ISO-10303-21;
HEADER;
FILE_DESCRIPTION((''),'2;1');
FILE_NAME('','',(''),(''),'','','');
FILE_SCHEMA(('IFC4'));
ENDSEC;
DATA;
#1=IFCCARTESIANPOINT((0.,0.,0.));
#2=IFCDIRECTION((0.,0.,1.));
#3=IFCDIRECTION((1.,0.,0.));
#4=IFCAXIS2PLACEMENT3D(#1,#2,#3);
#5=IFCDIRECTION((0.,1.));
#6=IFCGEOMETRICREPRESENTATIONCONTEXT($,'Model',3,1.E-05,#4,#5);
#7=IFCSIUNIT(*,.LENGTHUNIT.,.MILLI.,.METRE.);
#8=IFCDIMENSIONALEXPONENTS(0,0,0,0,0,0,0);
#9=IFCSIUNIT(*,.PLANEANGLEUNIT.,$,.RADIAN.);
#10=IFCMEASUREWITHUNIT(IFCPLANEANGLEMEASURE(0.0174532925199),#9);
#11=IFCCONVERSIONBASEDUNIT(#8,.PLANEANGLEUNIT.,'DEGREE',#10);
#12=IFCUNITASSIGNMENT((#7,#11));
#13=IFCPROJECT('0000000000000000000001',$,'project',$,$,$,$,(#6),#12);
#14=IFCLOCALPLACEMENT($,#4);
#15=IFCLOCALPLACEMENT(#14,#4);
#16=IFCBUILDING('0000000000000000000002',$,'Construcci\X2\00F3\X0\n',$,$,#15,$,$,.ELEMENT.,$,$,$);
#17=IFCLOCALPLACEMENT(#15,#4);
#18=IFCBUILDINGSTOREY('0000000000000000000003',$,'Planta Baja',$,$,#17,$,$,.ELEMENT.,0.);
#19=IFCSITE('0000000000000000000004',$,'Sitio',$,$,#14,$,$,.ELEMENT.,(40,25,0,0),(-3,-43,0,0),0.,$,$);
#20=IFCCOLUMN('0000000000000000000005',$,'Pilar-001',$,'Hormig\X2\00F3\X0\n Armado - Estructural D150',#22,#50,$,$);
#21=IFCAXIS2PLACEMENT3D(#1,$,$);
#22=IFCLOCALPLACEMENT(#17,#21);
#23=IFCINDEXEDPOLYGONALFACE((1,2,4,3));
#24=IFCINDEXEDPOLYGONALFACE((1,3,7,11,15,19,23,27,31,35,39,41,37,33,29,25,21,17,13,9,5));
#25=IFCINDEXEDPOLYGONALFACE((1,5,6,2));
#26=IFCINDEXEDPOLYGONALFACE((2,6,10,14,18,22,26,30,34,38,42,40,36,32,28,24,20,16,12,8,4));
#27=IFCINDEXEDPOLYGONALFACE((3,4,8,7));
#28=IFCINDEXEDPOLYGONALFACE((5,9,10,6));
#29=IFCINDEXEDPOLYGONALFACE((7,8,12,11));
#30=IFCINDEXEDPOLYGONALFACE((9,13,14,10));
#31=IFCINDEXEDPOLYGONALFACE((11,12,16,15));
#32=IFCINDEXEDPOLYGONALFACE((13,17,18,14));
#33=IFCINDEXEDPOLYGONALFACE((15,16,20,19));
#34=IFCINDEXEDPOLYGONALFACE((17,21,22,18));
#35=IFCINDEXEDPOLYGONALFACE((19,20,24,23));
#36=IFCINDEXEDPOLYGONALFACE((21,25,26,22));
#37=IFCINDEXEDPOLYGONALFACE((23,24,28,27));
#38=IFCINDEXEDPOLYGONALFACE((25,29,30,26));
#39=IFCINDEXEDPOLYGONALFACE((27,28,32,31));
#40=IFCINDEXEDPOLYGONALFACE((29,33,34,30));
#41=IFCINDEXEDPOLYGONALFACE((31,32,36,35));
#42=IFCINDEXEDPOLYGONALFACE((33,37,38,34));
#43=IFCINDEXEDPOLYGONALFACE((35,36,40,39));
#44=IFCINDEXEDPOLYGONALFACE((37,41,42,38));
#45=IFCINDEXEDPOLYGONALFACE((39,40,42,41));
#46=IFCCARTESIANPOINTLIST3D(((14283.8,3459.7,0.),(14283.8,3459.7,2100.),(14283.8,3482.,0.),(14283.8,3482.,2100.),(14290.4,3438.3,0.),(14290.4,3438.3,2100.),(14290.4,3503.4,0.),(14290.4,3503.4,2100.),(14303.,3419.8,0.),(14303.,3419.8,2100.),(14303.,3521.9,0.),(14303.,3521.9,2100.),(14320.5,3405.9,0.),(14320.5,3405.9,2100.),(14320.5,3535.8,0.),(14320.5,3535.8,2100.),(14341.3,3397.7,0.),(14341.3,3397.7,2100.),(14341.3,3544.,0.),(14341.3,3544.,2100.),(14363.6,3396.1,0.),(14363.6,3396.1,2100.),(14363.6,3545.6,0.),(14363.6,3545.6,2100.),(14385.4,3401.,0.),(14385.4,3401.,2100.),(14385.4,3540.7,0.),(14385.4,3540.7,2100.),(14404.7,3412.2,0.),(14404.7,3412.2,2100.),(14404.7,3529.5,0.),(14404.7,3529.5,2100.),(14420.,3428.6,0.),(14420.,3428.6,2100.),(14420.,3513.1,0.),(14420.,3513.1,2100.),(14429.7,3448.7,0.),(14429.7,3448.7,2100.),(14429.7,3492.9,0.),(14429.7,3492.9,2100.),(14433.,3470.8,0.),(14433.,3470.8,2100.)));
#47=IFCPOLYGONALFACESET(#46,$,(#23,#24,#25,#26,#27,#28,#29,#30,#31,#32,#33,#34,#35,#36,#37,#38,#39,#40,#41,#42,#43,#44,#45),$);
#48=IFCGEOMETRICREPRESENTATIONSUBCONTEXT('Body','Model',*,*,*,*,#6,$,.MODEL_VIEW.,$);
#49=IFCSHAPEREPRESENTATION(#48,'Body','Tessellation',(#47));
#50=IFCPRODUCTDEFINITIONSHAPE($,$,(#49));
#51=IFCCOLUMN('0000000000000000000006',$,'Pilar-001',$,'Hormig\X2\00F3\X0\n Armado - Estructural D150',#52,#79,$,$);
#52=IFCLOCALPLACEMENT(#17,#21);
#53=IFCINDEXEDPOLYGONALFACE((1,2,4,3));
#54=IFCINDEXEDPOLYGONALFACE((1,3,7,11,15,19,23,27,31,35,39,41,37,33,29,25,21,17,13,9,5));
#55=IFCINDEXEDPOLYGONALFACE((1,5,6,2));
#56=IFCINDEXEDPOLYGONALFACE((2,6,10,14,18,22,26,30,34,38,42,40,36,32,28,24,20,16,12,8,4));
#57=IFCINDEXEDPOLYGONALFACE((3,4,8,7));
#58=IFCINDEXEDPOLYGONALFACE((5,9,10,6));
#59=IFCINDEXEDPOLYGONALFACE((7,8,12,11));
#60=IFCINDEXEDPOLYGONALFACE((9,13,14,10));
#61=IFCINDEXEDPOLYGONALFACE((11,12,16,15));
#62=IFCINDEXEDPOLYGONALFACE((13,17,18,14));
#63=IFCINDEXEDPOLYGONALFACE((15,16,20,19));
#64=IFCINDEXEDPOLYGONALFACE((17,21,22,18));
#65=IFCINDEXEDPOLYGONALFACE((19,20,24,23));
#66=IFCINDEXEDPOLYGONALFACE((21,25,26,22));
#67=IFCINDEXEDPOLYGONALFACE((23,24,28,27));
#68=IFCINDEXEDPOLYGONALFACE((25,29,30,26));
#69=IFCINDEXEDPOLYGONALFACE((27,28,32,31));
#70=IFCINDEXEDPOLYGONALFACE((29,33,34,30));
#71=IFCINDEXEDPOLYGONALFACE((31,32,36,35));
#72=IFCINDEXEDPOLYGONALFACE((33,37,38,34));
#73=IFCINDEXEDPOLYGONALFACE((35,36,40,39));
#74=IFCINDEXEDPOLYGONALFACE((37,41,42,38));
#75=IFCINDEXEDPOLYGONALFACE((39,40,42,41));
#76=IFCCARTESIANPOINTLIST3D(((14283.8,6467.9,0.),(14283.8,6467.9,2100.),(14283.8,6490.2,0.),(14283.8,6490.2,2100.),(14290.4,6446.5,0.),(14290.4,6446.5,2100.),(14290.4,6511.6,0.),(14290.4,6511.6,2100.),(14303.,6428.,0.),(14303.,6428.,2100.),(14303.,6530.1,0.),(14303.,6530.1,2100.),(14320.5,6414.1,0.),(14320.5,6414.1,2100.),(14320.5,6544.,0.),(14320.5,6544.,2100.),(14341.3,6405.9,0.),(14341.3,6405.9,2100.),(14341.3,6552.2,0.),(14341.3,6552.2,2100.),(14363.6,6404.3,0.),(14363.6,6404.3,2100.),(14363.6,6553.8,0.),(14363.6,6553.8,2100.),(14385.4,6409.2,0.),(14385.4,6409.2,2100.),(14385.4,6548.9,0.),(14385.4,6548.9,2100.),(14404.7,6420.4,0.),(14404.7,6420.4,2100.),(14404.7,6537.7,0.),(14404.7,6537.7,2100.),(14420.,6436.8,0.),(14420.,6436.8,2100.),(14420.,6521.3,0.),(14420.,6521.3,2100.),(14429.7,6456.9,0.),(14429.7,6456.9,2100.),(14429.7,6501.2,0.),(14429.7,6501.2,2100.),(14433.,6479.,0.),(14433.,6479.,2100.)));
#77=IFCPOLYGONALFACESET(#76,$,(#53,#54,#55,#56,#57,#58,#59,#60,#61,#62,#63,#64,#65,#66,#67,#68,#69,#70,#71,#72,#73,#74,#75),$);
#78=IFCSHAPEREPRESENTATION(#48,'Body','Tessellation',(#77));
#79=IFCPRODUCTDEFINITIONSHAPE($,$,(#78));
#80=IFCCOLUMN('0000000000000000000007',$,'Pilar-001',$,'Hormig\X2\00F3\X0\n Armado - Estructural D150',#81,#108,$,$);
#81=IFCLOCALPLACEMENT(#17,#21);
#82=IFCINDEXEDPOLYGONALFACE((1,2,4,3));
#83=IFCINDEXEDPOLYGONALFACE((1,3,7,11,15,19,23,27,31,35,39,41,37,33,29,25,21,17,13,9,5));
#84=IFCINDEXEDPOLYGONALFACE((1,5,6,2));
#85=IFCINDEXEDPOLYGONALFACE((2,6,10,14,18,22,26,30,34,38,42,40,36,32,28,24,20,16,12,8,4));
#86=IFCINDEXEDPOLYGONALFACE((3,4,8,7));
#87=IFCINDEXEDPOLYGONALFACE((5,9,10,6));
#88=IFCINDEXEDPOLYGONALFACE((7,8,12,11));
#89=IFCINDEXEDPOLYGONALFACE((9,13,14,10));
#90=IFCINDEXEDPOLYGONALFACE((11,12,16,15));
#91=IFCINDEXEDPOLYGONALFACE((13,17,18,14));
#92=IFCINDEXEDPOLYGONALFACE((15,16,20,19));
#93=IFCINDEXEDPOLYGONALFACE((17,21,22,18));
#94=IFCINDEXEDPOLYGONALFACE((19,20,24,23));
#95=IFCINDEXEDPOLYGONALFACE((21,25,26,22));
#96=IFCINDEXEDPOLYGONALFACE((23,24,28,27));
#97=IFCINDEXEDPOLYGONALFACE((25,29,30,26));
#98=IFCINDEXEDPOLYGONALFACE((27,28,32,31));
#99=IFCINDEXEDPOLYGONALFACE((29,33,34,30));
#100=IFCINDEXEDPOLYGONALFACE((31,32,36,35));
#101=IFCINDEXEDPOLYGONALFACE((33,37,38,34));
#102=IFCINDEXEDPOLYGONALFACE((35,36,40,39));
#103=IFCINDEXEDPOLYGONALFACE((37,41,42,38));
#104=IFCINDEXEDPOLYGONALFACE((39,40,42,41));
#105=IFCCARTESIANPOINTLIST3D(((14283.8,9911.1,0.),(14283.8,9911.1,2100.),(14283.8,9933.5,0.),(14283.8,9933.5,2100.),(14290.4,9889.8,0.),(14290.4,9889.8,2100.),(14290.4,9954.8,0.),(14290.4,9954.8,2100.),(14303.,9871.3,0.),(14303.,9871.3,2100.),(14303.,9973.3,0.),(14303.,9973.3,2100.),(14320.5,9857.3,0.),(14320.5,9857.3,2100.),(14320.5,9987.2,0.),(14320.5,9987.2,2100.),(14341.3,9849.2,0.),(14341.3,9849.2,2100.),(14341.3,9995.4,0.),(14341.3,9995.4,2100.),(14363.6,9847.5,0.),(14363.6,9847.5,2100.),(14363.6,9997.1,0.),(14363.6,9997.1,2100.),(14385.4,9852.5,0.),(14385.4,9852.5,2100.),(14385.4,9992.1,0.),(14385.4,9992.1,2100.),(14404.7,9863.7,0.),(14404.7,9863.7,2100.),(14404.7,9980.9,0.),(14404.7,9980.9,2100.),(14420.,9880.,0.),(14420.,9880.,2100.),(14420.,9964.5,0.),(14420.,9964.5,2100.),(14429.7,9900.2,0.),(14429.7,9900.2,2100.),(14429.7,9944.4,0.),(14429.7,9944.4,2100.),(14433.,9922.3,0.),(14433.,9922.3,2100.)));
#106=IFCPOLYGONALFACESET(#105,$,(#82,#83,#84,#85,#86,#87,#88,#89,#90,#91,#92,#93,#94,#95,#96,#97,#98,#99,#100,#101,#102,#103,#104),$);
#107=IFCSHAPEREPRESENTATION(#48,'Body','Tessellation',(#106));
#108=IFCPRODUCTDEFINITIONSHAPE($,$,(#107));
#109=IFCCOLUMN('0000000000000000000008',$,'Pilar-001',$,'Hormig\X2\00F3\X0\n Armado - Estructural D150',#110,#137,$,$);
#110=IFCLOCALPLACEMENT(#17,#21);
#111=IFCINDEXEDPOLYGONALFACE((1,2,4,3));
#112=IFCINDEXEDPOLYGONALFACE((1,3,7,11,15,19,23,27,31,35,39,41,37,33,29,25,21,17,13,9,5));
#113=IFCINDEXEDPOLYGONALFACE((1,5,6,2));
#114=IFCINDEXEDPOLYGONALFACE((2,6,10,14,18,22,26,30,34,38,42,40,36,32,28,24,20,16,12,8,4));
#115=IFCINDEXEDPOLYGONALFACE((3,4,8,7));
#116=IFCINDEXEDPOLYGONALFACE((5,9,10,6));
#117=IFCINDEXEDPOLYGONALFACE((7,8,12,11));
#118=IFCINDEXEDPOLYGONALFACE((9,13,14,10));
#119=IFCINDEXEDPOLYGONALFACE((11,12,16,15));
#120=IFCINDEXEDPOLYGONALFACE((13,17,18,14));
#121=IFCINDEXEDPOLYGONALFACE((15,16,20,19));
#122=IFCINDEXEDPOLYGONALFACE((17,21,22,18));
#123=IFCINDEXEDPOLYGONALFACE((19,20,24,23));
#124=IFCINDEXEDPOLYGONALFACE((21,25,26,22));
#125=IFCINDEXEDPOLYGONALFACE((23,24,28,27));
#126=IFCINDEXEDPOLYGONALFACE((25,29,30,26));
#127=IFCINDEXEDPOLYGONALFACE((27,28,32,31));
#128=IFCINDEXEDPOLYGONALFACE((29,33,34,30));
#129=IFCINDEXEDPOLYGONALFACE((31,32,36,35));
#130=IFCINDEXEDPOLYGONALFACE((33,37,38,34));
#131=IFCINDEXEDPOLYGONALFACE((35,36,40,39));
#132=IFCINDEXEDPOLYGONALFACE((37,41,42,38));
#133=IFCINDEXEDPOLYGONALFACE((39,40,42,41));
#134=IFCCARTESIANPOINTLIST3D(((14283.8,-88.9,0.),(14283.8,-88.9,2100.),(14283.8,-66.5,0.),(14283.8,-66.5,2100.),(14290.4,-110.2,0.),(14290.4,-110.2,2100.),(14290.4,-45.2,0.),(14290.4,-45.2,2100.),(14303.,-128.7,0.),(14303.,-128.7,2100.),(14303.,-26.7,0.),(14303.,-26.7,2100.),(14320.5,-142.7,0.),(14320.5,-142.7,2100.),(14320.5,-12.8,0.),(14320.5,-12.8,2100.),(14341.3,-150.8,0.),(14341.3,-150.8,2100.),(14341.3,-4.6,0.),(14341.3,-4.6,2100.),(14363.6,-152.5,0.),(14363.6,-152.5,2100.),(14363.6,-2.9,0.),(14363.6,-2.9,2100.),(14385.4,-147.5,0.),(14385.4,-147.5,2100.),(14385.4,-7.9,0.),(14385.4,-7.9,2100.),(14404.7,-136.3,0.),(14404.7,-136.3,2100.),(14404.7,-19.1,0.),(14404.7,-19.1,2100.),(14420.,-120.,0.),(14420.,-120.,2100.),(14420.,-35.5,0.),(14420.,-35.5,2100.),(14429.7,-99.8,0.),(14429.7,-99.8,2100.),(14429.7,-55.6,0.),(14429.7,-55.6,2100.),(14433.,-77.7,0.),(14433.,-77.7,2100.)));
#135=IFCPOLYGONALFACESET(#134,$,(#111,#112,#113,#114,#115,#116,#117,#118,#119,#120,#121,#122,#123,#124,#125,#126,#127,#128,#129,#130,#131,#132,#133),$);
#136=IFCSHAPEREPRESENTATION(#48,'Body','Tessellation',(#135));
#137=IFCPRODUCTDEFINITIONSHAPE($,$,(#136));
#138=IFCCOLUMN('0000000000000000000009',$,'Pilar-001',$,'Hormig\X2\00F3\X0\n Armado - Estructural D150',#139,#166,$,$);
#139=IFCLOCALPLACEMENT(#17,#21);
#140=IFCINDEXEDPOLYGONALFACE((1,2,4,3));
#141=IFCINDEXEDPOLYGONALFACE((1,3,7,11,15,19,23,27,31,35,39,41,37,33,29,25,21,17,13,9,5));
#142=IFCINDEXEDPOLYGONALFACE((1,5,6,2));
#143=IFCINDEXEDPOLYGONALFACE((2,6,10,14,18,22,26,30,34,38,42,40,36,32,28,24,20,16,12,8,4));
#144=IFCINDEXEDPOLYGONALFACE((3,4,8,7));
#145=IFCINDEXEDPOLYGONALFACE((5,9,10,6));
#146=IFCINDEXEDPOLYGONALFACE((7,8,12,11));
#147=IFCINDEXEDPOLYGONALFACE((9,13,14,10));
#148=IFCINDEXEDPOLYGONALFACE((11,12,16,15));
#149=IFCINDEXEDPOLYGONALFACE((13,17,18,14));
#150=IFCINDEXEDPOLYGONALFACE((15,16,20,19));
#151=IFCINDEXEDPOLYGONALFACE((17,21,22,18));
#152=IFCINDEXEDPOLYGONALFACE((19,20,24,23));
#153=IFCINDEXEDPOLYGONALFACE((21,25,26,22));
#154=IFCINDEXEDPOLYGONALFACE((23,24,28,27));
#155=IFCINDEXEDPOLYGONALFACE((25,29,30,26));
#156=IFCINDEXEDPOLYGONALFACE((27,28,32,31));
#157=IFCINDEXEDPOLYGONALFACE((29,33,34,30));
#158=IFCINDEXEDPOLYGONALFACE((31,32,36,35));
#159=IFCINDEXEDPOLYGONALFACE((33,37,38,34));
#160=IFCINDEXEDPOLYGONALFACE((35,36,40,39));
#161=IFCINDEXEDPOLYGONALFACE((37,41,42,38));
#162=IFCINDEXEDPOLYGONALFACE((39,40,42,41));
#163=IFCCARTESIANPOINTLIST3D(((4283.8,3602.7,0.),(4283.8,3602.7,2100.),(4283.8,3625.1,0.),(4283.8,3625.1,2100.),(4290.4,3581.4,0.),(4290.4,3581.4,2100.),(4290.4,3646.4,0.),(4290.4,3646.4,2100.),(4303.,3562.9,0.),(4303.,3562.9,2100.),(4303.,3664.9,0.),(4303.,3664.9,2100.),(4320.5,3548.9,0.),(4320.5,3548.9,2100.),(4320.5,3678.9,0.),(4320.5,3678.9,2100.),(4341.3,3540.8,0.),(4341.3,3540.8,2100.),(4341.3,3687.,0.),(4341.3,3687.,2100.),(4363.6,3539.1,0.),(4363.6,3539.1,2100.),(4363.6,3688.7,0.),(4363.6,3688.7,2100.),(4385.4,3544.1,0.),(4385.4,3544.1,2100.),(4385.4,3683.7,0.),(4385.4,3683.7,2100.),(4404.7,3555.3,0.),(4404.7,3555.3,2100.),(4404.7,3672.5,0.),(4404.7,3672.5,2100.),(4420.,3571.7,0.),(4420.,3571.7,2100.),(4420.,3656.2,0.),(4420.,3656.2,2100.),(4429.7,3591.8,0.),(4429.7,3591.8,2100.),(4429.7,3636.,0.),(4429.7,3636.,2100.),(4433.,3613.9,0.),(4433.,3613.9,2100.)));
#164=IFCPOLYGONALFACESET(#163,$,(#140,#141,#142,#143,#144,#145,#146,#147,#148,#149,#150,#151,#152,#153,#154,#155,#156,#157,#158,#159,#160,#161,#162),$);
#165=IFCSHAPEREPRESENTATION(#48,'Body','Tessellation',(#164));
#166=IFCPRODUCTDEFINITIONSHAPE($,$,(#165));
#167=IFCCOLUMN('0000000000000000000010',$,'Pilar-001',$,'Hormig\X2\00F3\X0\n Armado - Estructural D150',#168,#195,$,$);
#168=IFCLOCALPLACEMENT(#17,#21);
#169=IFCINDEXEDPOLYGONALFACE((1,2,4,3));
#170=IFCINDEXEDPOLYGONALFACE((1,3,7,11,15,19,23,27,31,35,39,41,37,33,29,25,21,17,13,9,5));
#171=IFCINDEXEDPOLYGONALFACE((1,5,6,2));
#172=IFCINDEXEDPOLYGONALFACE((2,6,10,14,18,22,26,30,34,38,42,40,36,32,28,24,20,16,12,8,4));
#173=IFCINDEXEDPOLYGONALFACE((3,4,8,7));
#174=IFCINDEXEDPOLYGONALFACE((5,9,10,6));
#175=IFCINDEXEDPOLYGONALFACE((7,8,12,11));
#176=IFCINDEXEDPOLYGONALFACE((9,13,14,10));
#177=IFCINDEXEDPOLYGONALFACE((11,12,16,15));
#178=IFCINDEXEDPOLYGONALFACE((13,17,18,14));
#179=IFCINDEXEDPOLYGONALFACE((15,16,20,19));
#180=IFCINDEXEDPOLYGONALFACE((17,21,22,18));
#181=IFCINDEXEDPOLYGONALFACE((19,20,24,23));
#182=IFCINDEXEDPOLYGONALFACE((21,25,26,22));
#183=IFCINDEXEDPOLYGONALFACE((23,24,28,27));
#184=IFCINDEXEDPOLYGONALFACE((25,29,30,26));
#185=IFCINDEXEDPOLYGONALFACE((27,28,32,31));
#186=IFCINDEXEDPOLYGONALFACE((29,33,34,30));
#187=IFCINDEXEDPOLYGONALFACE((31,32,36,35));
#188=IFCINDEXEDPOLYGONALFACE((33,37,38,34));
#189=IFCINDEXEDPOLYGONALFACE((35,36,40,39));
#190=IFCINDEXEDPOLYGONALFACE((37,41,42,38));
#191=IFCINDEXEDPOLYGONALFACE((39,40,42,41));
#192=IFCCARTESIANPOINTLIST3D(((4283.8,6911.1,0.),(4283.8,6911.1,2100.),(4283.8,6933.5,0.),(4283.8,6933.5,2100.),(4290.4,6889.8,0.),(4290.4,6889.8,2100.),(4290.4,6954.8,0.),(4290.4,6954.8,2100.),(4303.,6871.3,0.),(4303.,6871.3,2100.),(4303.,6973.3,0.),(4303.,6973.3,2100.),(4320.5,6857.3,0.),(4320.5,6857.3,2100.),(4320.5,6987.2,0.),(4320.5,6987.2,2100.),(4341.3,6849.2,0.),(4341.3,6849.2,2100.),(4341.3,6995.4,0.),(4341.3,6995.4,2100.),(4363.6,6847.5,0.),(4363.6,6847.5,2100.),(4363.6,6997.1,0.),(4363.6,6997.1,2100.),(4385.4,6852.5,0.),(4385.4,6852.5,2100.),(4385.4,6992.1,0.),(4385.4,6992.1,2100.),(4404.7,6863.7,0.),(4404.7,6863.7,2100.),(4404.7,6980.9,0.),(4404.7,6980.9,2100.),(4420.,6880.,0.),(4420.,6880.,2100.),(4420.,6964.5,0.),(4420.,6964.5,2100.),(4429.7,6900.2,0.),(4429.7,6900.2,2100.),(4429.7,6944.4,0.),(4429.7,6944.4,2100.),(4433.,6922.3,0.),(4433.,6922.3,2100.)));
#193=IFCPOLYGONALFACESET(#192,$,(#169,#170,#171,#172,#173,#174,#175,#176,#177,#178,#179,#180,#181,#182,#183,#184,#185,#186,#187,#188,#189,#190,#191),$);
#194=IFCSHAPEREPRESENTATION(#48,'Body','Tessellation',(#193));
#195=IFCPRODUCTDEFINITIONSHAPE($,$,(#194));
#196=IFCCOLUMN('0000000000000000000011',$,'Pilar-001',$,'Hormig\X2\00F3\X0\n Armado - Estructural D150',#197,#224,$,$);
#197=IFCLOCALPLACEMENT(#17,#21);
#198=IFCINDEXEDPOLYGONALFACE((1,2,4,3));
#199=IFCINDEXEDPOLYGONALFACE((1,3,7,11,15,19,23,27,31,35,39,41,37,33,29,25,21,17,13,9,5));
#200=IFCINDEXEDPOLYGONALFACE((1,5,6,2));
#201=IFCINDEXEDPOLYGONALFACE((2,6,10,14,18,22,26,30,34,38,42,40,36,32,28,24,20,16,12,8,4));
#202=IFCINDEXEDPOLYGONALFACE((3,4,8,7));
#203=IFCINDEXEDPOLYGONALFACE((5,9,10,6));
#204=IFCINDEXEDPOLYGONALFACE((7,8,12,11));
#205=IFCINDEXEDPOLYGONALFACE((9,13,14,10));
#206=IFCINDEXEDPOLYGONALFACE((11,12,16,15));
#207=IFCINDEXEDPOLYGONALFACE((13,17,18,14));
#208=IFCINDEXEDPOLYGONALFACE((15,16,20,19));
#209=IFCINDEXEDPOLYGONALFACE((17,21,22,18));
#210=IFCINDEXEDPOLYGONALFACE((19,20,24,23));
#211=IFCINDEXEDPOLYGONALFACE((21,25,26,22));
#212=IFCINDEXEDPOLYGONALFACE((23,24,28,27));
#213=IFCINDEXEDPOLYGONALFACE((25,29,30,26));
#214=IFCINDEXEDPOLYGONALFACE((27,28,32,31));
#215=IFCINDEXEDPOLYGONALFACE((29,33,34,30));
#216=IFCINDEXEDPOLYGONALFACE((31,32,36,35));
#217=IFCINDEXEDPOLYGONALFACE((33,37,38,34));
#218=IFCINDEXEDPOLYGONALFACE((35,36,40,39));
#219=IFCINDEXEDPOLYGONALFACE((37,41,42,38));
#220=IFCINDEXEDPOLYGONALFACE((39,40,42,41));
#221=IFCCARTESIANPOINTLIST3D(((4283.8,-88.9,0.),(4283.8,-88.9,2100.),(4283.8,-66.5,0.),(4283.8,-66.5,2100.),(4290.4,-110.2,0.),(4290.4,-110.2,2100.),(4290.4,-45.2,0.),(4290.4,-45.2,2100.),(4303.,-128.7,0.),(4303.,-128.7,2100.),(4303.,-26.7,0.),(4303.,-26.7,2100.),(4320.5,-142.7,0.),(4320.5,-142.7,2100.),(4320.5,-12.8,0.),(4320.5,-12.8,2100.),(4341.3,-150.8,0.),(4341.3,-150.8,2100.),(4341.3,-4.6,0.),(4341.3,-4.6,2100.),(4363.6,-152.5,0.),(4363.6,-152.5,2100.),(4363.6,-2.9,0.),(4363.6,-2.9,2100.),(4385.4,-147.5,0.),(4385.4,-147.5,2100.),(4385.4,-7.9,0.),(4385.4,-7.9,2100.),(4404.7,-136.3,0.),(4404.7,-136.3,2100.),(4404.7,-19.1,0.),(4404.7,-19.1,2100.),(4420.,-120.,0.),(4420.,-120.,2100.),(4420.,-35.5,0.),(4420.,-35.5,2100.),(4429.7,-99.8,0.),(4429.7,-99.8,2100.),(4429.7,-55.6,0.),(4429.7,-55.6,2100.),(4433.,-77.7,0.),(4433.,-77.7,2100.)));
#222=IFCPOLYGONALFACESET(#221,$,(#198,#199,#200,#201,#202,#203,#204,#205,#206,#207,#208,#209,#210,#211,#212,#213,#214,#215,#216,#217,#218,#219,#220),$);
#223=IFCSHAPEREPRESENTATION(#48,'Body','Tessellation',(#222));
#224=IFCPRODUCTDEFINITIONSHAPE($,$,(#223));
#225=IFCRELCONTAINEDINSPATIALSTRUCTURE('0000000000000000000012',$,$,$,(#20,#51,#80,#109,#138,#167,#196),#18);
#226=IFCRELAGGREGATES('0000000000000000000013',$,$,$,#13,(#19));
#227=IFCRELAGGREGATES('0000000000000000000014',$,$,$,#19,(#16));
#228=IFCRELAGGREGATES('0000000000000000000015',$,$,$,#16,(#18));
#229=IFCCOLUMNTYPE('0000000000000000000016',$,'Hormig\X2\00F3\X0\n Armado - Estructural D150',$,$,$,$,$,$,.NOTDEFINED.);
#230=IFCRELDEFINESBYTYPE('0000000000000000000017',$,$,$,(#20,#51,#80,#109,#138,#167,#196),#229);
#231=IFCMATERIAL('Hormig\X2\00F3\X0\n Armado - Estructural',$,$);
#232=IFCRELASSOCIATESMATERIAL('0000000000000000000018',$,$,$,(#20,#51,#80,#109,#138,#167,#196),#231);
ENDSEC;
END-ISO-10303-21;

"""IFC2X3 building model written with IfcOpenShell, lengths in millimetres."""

from ifc_helpers import new_model, entity, si_unit, converted_unit, direction, frame, origin_with_axes, origin_2d_with_axis, place, context, subcontext, project, spatial, circle, extrude, material, type_object, element, save


model = new_model("IFC2X3")

# Units and contexts
model_context = context("Model", 3, precision=1e-05, world=origin_with_axes(), true_north=direction((0.0, 1.0)))
body_context = subcontext(model_context, "Body", "Model", "MODEL_VIEW")
ifc_project = project(units=[si_unit("LENGTHUNIT", "METRE", prefix="MILLI"), converted_unit("PLANEANGLEUNIT", "DEGREE", entity("IfcPlaneAngleMeasure", 0.0174532925199), si_unit("PLANEANGLEUNIT", "RADIAN"), dimensions=[0, 0, 0, 0, 0, 0, 0])], contexts=[model_context])

# Site, building, storey
site_placement = place(None, origin_with_axes())
site = spatial("IfcSite", under=ifc_project, at=site_placement, Name="Sitio", CompositionType="ELEMENT", RefLatitude=(40, 25, 0, 0), RefLongitude=(-3, -43, 0, 0), RefElevation=0.0)
building_placement = place(site_placement, origin_with_axes())
building = spatial("IfcBuilding", under=site, at=building_placement, Name="Construcción", CompositionType="ELEMENT")
storey_placement = place(building_placement, origin_with_axes())
storey = spatial("IfcBuildingStorey", under=building, at=storey_placement, Name="Planta Baja", CompositionType="ELEMENT", Elevation=0.0)

# Columns
ifc_material_1 = material(Name="Hormigón Armado - Estructural")
column_type_1 = type_object("IfcColumnType", Name="Hormigón Armado - Estructural D150", PredefinedType="NOTDEFINED")
for number, where, z_axis, x_axis, name in (
    (1, (14358.0, 3470.8, 0.0), (0.0, 0.0, 1.0), (1.0, 0.0, 0.0), "Pilar-001"),
    (2, (14358.0, 6479.0, 0.0), (0.0, 0.0, 1.0), (1.0, 0.0, 0.0), "Pilar-001"),
    (3, (14358.0, 9922.3, 0.0), (0.0, 0.0, 1.0), (1.0, 0.0, 0.0), "Pilar-001"),
    (4, (14358.0, -77.7, 0.0), (0.0, 0.0, 1.0), (1.0, 0.0, 0.0), "Pilar-001"),
    (5, (4358.0, 3613.9, 0.0), (0.0, 0.0, 1.0), (1.0, 0.0, 0.0), "Pilar-001"),
    (6, (4358.0, 6922.3, 0.0), (0.0, 0.0, 1.0), (1.0, 0.0, 0.0), "Pilar-001"),
    (7, (4358.0, -77.7, 0.0), (0.0, 0.0, 1.0), (1.0, 0.0, 0.0), "Pilar-001"),
):
    element("IfcColumn", number, at=place(storey_placement, frame(where, z_axis=z_axis, x_axis=x_axis)), inside=storey, type_object=column_type_1, material=ifc_material_1, Name=name, ObjectType="Hormigón Armado - Estructural D150", context=body_context, shape_type="SweptSolid", body=[
        extrude(circle(Radius=75.0, at=origin_2d_with_axis()), origin_with_axes(), (0.0, 0.0, 1.0), 2100.0),
    ])

save(model, "model.ifc")
